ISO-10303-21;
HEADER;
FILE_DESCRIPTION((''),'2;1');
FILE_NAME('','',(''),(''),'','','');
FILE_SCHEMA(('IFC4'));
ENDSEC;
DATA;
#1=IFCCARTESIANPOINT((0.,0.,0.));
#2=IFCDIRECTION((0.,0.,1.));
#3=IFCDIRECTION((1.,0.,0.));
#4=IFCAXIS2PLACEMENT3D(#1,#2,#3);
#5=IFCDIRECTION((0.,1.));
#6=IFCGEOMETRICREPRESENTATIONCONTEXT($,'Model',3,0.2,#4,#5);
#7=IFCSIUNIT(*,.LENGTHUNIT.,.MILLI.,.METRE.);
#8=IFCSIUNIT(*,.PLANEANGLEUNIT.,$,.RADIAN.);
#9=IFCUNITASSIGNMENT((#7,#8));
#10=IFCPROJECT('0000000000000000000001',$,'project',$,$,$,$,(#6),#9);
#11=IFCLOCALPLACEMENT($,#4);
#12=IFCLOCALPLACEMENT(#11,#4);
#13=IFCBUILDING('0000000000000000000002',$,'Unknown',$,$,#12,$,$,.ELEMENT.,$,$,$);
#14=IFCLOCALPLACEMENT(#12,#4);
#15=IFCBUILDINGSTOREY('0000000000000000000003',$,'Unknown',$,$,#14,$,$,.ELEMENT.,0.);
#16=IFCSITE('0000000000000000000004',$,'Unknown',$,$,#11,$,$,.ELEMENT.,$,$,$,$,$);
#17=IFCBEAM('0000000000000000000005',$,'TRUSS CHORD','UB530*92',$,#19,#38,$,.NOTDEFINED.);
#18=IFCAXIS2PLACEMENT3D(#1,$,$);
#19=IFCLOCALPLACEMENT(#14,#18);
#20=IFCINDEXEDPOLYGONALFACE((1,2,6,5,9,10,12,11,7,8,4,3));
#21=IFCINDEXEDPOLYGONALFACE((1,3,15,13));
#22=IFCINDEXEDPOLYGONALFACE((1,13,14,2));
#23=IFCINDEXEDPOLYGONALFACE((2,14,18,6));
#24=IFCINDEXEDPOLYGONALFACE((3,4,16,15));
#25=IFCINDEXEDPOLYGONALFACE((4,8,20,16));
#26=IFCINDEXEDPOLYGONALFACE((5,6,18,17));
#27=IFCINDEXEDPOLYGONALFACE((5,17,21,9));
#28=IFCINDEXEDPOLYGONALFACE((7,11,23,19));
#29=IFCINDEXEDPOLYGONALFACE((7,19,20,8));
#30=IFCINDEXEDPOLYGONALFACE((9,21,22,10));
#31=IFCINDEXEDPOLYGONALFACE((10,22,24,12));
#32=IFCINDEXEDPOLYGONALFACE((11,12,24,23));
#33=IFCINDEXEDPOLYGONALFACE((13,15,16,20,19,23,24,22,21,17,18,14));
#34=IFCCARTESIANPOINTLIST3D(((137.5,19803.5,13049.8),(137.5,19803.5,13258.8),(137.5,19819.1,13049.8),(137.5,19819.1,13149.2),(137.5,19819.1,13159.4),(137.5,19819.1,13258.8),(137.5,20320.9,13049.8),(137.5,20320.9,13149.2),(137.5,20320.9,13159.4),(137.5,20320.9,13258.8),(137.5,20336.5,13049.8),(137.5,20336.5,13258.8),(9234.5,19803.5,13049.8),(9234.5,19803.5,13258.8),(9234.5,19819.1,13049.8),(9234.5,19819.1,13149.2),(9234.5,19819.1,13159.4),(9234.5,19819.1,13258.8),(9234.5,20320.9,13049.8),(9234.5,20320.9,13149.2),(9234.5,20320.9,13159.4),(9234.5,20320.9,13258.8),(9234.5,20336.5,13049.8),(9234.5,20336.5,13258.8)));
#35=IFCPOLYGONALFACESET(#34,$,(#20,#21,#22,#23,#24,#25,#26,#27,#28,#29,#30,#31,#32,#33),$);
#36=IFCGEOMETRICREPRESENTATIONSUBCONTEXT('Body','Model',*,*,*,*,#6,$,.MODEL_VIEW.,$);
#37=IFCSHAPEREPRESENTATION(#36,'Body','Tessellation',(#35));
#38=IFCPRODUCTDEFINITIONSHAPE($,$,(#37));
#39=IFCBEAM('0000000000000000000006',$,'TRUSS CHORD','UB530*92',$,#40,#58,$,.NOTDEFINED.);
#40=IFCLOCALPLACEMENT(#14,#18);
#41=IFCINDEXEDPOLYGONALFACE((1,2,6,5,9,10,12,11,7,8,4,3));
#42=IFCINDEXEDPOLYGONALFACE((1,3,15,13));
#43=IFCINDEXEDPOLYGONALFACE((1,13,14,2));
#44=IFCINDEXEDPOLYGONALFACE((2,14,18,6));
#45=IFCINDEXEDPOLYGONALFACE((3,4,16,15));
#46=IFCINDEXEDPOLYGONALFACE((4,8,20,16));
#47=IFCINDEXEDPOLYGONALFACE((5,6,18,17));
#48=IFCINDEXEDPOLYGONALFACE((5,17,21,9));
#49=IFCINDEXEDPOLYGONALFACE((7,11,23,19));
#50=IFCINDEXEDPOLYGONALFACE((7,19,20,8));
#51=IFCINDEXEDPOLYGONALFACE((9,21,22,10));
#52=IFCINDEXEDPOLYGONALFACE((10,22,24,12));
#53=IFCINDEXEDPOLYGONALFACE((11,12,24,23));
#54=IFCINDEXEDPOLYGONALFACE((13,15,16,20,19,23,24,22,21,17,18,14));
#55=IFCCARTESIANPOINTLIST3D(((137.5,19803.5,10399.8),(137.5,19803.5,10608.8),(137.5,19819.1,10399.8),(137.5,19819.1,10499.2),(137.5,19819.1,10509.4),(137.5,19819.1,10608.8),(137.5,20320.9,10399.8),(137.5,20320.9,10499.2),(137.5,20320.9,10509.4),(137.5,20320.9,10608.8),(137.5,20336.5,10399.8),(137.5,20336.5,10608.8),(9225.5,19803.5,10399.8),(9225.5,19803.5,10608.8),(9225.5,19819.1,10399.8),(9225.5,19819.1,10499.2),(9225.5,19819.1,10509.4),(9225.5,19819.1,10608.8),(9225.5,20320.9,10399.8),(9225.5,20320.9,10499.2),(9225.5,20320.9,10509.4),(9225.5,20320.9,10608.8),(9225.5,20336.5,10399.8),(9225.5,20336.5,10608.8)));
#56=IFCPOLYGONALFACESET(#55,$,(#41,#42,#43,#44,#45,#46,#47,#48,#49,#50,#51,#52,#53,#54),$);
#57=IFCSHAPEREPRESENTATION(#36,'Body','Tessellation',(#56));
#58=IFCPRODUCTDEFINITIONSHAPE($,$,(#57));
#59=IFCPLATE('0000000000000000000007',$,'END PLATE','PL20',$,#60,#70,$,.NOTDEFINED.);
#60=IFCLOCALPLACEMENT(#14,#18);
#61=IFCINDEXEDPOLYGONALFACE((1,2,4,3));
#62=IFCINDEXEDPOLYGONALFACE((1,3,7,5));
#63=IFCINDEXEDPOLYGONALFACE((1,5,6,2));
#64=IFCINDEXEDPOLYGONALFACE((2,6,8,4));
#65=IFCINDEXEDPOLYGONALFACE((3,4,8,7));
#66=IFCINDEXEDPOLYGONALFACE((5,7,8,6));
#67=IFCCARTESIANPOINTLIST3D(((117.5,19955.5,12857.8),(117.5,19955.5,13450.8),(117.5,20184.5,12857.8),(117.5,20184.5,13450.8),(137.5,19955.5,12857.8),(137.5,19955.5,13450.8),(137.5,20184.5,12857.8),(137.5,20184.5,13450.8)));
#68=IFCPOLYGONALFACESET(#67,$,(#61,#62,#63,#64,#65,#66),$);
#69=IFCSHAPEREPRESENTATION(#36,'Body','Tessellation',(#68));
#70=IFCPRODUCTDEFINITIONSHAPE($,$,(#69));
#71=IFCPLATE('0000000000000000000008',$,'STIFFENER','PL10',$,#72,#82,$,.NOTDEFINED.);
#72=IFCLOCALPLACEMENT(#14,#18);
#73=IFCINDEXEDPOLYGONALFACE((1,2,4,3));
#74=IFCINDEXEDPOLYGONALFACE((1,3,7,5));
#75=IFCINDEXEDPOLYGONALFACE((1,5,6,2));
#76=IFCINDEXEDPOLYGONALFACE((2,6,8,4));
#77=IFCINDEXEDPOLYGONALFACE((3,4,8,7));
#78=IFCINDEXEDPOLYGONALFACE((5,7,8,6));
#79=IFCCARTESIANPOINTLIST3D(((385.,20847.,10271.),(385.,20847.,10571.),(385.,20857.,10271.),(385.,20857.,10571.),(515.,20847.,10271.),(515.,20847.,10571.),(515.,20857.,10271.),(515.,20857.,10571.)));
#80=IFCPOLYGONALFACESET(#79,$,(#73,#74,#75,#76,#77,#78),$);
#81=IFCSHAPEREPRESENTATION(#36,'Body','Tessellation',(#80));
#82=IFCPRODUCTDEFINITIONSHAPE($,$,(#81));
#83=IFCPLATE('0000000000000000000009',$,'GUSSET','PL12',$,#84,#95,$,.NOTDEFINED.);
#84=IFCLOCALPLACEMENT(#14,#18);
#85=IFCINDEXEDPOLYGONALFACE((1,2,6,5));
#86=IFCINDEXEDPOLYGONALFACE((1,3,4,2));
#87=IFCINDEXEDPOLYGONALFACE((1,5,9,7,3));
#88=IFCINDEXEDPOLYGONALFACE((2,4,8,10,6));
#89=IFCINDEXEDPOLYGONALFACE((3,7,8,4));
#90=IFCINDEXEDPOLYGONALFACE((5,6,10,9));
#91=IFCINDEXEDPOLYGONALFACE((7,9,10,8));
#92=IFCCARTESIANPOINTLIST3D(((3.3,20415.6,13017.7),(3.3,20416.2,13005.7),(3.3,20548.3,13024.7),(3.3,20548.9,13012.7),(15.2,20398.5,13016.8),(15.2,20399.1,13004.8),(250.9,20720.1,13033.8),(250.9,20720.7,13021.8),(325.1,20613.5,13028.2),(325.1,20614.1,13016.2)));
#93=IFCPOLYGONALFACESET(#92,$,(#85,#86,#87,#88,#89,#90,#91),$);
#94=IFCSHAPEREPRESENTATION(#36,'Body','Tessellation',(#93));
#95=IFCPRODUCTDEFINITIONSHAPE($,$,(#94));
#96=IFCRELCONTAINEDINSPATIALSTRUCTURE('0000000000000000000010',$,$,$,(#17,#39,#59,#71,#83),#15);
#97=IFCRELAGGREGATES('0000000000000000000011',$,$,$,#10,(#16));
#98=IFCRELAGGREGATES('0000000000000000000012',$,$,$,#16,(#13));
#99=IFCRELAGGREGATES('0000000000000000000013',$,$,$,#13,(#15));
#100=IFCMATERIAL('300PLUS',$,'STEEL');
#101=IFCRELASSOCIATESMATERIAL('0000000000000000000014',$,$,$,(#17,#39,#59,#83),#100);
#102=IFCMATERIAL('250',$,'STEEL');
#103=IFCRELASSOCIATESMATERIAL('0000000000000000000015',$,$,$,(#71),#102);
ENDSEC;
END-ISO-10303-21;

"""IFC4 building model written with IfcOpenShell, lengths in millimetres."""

from ifc_helpers import new_model, si_unit, direction, frame, origin_with_axes, place, context, subcontext, project, spatial, line, indexed_curve, outline, extrude, material, element, save


model = new_model("IFC4")

# Units and contexts
model_context = context("Model", 3, precision=0.2, world=origin_with_axes(), true_north=direction((0.0, 1.0)))
body_context = subcontext(model_context, "Body", "Model", "MODEL_VIEW")
ifc_project = project(units=[si_unit("LENGTHUNIT", "METRE", prefix="MILLI"), si_unit("PLANEANGLEUNIT", "RADIAN")], contexts=[model_context])

# Site, building, storey
site_placement = place(None, origin_with_axes())
site = spatial("IfcSite", under=ifc_project, at=site_placement, Name="Unknown", CompositionType="ELEMENT")
building_placement = place(site_placement, origin_with_axes())
building = spatial("IfcBuilding", under=site, at=building_placement, Name="Unknown", CompositionType="ELEMENT")
storey_placement = place(building_placement, origin_with_axes())
storey = spatial("IfcBuildingStorey", under=building, at=storey_placement, Name="Unknown", CompositionType="ELEMENT", Elevation=0.0)

# Beams
ifc_material_1 = material(Name="300PLUS", Category="STEEL")
beam_1_placement = place(storey_placement, frame((137.5, 20070.0, 13154.3), z_axis=(0.0, 0.0, 1.0), x_axis=(1.0, 0.0, 0.0)))
element("IfcBeam", 1, at=beam_1_placement, inside=storey, material=ifc_material_1, Name="TRUSS CHORD", Description="UB530*92", PredefinedType="NOTDEFINED", context=body_context, shape_type="SolidModel", body=[
    extrude(outline(indexed_curve([(-104.5, -266.5), (104.5, -266.5), (104.5, -250.9), (5.1, -250.9), (5.1, 250.9), (104.5, 250.9), (104.5, 266.5), (-104.5, 266.5), (-104.5, 250.9), (-5.1, 250.9), (-5.1, -250.9), (-104.5, -250.9)], segments=[line(1, 2, 3, 4, 5, 6, 7, 8, 9, 10, 11, 12, 1)])), frame((0.0, 0.0, 0.0), z_axis=(-1.0, 0.0, 0.0), x_axis=(0.0, 0.0, 1.0)), (0.0, 0.0, -1.0), 9097.0),
])
beam_2_placement = place(storey_placement, frame((137.5, 20070.0, 10504.3), z_axis=(0.0, 0.0, 1.0), x_axis=(1.0, 0.0, 0.0)))
element("IfcBeam", 2, at=beam_2_placement, inside=storey, material=ifc_material_1, Name="TRUSS CHORD", Description="UB530*92", PredefinedType="NOTDEFINED", context=body_context, shape_type="SolidModel", body=[
    extrude(outline(indexed_curve([(-104.5, -266.5), (104.5, -266.5), (104.5, -250.9), (5.1, -250.9), (5.1, 250.9), (104.5, 250.9), (104.5, 266.5), (-104.5, 266.5), (-104.5, 250.9), (-5.1, 250.9), (-5.1, -250.9), (-104.5, -250.9)], segments=[line(1, 2, 3, 4, 5, 6, 7, 8, 9, 10, 11, 12, 1)])), frame((0.0, 0.0, 0.0), z_axis=(-1.0, 0.0, 0.0), x_axis=(0.0, 0.0, 1.0)), (0.0, 0.0, -1.0), 9088.0),
])

# Plates
plate_1_placement = place(storey_placement, frame((127.5, 20184.5, 12857.8), z_axis=(-1.0, 0.0, 0.0), x_axis=(0.0, -1.0, 0.0)))
element("IfcPlate", 3, at=plate_1_placement, inside=storey, material=ifc_material_1, Name="END PLATE", Description="PL20", PredefinedType="NOTDEFINED", context=body_context, shape_type="SolidModel", body=[
    extrude(outline(indexed_curve([(0.0, 0.0), (229.0, 0.0), (229.0, 593.0), (0.0, 593.0)], segments=[line(1, 2, 3, 4, 1)])), frame((0.0, 0.0, 10.0), z_axis=(0.0, 0.0, 1.0), x_axis=(1.0, 0.0, 0.0)), (0.0, 0.0, -1.0), 20.0),
])
ifc_material_2 = material(Name="250", Category="STEEL")
plate_2_placement = place(storey_placement, frame((385.0, 20852.0, 10571.0), z_axis=(0.0, 1.0, 0.0), x_axis=(1.0, 0.0, 0.0)))
element("IfcPlate", 4, at=plate_2_placement, inside=storey, material=ifc_material_2, Name="STIFFENER", Description="PL10", PredefinedType="NOTDEFINED", context=body_context, shape_type="SolidModel", body=[
    extrude(outline(indexed_curve([(0.0, 0.0), (130.0, 0.0), (130.0, 300.0), (0.0, 300.0)], segments=[line(1, 2, 3, 4, 1)])), frame((0.0, 0.0, 5.0), z_axis=(0.0, 0.0, 1.0), x_axis=(1.0, 0.0, 0.0)), (0.0, 0.0, -1.0), 10.0),
])
plate_3_placement = place(storey_placement, frame((3.3, 20415.9, 13011.7), z_axis=(-0.000171, -0.052677, 0.998612), x_axis=(0.570673, -0.820042, -0.04316)))
element("IfcPlate", 5, at=plate_3_placement, inside=storey, material=ifc_material_1, Name="GUSSET", Description="PL12", PredefinedType="NOTDEFINED", context=body_context, shape_type="SolidModel", body=[
    extrude(outline(indexed_curve([(0.0, 0.0), (20.9, 0.0), (20.9, 377.3), (-109.1, 377.3), (-109.1, 75.8)], segments=[line(1, 2, 3, 4, 5, 1)])), frame((0.0, 0.0, 6.0), z_axis=(0.0, 0.0, 1.0), x_axis=(1.0, 0.0, 0.0)), (0.0, 0.0, -1.0), 12.0),
])

save(model, "model.ifc")
